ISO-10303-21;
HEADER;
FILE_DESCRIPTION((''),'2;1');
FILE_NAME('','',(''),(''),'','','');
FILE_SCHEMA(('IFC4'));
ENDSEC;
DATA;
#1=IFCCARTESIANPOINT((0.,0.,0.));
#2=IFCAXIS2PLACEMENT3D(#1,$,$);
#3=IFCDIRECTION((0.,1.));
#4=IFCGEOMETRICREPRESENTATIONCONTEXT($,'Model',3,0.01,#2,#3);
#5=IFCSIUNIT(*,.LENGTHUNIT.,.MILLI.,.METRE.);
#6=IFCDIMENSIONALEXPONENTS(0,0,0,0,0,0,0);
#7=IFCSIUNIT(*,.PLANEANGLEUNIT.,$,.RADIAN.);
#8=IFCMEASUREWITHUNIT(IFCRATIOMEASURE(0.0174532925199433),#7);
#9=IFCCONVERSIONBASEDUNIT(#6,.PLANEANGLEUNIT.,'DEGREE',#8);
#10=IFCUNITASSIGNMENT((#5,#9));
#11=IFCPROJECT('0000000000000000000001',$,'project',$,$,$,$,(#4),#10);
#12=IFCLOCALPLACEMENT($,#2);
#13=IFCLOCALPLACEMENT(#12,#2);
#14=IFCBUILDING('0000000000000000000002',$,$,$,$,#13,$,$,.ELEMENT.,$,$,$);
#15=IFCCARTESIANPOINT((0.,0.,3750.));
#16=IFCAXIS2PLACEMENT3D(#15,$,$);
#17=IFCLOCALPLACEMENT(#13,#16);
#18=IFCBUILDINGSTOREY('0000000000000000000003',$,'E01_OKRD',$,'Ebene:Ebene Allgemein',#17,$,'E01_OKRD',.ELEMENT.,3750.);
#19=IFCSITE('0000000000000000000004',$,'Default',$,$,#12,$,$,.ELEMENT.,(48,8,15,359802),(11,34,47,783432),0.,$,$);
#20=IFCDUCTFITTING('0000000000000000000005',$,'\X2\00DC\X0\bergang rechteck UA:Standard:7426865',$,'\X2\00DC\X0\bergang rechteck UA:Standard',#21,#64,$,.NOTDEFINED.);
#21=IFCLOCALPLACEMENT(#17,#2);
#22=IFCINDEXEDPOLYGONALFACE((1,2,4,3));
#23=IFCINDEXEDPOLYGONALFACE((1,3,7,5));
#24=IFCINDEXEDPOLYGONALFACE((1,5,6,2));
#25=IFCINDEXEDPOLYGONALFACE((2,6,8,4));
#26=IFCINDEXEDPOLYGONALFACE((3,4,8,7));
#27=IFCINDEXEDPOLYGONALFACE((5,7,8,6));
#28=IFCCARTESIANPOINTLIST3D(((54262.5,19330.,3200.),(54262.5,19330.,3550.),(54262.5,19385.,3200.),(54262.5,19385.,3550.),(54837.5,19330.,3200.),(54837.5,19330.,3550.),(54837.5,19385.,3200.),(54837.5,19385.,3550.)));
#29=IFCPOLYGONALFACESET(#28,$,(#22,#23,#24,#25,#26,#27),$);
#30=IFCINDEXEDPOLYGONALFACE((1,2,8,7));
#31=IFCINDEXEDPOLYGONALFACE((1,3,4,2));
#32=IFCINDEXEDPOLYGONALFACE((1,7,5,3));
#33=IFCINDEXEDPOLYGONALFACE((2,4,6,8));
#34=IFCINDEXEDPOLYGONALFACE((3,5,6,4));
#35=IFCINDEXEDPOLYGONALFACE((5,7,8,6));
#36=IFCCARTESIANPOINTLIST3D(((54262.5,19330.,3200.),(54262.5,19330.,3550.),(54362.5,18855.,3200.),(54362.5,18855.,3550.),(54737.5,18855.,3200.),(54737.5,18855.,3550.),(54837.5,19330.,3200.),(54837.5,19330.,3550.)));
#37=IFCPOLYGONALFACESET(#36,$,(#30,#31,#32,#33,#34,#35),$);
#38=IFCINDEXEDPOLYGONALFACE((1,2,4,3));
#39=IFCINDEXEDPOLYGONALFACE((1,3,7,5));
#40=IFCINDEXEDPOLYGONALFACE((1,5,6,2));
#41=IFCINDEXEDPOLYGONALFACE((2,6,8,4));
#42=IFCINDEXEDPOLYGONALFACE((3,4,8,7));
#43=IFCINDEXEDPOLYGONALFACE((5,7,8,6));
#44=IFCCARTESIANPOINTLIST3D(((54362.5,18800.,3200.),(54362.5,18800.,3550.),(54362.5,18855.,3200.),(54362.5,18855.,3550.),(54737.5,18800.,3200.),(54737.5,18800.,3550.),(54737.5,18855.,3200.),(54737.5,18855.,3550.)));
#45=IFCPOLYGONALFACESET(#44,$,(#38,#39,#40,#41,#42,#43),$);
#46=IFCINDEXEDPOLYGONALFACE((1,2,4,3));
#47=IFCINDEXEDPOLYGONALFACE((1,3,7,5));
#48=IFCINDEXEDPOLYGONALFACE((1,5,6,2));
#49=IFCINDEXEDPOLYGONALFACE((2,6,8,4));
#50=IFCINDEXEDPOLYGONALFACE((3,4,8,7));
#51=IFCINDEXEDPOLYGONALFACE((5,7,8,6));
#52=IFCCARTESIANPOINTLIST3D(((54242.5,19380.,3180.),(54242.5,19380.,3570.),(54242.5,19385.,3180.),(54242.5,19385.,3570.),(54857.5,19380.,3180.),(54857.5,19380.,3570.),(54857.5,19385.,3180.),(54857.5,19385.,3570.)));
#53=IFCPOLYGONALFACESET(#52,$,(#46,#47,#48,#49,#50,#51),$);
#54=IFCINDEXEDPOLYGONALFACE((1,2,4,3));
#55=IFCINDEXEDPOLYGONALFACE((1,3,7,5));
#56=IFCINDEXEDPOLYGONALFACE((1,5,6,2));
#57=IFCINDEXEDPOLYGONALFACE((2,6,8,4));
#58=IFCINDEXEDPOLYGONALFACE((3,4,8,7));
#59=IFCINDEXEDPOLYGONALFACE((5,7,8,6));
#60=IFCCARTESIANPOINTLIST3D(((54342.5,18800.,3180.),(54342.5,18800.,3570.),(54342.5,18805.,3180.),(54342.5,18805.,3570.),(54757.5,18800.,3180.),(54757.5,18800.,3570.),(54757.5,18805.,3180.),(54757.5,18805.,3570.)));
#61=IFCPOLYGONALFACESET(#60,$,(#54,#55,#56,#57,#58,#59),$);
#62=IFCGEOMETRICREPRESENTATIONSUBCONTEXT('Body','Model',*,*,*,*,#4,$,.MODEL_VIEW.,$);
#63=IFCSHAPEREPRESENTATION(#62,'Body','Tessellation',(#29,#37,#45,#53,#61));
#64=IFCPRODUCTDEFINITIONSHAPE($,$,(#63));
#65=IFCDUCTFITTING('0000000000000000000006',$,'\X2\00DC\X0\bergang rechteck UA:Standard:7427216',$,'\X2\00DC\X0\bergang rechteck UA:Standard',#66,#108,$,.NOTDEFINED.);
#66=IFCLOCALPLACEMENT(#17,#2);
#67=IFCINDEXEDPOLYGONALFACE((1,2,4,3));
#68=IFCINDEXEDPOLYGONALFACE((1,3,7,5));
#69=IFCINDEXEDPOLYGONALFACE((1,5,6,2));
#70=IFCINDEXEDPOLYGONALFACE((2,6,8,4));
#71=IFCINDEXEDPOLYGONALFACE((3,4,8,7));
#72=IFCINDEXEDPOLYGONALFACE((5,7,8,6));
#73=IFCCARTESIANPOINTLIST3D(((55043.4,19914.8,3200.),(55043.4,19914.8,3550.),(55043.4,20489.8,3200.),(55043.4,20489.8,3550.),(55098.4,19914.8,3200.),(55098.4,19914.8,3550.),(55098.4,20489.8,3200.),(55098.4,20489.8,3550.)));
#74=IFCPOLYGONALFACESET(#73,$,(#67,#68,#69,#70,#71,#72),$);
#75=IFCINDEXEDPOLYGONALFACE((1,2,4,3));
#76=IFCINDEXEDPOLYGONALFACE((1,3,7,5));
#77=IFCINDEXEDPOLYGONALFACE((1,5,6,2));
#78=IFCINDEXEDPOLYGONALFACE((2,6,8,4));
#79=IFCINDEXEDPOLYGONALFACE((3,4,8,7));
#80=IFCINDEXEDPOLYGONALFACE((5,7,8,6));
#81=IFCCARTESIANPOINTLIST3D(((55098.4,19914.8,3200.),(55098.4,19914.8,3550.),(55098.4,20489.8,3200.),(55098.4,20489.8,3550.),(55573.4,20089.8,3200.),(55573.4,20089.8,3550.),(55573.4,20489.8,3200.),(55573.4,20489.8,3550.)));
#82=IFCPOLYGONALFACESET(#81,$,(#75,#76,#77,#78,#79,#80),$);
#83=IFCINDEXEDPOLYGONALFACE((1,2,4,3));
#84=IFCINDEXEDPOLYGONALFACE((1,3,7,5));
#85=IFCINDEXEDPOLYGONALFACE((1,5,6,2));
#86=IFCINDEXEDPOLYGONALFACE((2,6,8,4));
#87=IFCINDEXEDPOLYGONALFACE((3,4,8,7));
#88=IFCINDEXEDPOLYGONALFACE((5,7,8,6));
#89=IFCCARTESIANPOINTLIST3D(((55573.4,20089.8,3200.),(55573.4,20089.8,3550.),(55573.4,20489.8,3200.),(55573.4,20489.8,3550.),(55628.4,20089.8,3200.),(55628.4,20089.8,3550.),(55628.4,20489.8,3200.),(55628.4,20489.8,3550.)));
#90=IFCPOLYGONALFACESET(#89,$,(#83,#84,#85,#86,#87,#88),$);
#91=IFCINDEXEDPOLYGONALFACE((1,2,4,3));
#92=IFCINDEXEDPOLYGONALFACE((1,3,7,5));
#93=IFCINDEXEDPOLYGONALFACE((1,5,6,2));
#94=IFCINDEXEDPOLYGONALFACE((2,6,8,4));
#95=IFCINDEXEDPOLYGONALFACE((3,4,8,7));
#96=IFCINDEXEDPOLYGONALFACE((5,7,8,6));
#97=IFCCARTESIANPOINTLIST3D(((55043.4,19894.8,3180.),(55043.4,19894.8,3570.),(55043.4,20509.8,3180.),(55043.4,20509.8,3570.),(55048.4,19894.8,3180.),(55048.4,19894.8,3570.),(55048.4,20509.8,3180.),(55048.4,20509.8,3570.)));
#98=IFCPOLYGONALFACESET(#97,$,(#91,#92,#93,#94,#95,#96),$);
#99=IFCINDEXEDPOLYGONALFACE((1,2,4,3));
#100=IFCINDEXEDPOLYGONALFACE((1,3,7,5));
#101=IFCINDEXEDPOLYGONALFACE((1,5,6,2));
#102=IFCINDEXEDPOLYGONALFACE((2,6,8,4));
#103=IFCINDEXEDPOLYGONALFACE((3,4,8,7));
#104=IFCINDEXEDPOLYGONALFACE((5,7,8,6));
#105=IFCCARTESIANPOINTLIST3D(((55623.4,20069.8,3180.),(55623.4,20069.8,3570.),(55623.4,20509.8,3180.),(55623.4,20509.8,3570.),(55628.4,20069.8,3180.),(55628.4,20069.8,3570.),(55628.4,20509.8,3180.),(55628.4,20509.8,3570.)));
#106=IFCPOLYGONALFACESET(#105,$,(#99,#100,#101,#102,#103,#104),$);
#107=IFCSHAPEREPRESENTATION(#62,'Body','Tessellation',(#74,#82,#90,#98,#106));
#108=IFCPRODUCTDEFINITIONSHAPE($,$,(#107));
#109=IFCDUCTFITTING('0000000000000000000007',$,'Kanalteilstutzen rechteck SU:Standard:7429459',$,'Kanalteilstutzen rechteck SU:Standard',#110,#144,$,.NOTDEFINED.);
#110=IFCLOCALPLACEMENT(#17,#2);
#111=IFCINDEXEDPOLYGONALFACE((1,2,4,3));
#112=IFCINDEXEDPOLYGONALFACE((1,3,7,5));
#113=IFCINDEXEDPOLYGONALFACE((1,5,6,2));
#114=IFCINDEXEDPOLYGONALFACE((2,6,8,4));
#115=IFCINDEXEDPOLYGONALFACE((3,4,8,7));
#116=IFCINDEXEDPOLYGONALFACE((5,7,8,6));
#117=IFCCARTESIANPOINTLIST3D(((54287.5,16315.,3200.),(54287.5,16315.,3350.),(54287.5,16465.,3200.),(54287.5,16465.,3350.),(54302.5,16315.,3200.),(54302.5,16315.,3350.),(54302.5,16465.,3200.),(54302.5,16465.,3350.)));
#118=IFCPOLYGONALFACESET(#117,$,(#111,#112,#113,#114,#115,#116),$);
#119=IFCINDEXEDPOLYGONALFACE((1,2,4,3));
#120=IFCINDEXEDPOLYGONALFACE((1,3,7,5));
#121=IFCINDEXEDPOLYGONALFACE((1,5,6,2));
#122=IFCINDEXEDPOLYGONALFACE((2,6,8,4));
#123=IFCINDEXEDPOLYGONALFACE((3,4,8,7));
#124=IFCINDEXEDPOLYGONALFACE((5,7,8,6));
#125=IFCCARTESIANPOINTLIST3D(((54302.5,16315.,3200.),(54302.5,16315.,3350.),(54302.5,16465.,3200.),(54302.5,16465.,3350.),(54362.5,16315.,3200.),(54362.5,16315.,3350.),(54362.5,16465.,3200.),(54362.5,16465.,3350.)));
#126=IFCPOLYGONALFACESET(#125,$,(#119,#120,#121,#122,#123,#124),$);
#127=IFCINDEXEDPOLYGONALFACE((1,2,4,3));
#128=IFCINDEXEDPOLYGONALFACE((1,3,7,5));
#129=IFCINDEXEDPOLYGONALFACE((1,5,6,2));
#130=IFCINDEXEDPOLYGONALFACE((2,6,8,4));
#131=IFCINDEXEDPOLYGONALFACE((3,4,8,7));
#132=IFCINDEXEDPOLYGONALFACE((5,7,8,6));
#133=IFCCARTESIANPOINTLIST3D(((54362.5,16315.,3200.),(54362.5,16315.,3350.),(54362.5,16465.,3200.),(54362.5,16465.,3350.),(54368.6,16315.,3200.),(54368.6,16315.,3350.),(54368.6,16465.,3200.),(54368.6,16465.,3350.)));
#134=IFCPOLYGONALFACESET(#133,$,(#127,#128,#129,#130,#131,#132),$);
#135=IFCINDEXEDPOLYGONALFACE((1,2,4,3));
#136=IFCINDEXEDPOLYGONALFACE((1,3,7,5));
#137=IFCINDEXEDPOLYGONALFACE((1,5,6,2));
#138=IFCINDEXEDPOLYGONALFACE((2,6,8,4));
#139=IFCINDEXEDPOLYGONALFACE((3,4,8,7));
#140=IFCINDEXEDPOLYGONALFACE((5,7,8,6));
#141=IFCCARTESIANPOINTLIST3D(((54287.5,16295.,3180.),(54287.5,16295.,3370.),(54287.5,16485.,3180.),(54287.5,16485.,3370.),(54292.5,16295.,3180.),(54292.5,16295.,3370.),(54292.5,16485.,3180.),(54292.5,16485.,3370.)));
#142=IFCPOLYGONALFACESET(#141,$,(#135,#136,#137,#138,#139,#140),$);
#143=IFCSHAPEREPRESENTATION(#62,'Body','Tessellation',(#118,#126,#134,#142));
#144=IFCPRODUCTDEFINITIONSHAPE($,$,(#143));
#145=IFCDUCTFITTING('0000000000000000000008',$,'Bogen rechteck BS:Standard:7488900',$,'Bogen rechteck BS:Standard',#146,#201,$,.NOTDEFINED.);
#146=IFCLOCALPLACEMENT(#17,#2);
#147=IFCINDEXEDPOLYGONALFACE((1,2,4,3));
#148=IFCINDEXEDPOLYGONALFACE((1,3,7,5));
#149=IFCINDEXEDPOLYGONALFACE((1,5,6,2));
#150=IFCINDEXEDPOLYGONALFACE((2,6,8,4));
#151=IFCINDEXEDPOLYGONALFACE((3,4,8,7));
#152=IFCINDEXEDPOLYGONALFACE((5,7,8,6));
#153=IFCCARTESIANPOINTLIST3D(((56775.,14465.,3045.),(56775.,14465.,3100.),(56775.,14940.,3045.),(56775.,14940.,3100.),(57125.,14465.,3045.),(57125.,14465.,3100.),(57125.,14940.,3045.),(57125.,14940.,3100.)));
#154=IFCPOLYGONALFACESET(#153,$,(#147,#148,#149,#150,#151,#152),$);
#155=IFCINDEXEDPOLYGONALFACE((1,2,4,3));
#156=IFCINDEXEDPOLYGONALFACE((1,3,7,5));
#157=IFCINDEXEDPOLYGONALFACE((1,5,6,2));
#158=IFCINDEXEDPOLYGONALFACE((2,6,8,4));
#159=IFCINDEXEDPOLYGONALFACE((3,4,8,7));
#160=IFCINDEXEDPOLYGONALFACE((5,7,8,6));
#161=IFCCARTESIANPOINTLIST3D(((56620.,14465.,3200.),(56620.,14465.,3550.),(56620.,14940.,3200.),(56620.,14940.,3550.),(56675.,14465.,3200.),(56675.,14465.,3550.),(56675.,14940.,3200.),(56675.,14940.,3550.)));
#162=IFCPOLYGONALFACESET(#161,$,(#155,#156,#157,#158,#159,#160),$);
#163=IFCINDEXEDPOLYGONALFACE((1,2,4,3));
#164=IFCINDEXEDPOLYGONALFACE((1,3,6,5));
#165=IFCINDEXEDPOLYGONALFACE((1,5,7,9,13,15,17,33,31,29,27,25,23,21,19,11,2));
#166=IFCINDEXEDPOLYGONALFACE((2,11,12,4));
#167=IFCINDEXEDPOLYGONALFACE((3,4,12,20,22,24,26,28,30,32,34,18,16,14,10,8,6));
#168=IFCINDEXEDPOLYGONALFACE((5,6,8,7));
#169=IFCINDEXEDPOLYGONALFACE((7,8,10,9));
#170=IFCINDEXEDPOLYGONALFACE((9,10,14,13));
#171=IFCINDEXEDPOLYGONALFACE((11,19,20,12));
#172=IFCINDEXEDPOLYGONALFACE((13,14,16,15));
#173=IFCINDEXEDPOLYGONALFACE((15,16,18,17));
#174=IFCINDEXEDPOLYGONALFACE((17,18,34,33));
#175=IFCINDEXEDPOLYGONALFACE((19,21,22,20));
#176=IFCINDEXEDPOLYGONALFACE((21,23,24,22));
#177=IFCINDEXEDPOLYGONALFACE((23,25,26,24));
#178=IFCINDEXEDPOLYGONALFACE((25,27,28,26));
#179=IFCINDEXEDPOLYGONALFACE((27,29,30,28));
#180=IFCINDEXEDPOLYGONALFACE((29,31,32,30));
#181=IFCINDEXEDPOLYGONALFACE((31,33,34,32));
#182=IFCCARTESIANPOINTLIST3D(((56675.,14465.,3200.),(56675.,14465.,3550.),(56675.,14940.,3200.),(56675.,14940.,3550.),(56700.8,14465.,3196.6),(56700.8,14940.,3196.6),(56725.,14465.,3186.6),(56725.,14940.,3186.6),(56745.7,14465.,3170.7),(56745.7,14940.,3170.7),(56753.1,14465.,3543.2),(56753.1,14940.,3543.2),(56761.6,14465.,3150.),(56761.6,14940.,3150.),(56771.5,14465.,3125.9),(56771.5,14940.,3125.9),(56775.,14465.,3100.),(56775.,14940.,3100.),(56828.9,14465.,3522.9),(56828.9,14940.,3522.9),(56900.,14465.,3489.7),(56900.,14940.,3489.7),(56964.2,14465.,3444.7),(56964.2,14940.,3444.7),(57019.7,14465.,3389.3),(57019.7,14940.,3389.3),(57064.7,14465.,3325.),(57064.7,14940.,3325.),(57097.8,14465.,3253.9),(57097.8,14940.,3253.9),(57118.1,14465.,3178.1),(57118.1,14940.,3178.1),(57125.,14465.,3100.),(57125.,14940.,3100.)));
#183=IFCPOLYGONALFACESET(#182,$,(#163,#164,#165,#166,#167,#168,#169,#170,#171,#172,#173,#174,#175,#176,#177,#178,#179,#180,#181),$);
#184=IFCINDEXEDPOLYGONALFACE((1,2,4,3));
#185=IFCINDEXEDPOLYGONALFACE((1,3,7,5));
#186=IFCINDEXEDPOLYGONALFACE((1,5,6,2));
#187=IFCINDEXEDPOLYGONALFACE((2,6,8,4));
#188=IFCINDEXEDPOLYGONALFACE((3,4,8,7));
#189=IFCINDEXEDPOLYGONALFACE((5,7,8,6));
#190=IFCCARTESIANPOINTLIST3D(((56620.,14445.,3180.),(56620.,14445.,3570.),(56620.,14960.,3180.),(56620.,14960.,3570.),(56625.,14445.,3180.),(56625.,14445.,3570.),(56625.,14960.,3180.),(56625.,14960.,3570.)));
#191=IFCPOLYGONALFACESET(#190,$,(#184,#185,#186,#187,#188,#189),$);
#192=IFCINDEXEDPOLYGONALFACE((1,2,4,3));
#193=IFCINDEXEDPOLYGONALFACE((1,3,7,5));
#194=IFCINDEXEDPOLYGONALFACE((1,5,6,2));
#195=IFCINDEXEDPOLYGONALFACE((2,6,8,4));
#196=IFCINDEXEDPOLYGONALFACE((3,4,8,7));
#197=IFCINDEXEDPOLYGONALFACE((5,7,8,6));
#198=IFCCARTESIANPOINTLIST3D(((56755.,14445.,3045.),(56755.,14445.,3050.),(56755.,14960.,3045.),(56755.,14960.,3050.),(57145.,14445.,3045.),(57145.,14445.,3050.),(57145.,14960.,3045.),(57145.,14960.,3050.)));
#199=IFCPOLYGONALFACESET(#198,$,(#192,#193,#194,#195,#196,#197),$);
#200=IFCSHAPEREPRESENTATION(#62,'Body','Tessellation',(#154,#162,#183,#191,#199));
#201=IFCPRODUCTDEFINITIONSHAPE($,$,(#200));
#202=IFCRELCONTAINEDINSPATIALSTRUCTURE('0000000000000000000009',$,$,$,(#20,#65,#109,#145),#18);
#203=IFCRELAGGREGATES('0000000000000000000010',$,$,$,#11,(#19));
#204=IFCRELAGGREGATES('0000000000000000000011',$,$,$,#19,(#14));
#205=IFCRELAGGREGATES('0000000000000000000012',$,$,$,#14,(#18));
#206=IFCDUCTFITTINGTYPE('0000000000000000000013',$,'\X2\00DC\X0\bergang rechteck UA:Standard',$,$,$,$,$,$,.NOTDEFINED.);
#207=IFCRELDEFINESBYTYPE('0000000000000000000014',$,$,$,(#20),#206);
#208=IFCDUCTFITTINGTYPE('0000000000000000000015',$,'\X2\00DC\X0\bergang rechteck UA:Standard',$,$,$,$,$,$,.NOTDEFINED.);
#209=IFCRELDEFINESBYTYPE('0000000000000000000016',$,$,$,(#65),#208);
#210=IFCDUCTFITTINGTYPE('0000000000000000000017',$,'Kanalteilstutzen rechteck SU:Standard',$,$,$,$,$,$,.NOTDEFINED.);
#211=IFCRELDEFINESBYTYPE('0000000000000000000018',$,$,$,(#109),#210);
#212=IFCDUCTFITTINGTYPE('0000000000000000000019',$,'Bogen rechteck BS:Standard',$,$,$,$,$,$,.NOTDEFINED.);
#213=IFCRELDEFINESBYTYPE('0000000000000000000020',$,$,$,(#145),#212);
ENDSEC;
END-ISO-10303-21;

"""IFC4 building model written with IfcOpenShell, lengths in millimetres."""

from ifc_helpers import new_model, entity, si_unit, converted_unit, direction, frame, frame_2d, origin, origin_2d_with_axis, place, context, subcontext, project, spatial, polyline, circle_curve, parameter, trimmed, segment, composite_curve, rectangle, outline, extrude, source, transform, mapped, type_object, type_shapes, element, save


model = new_model("IFC4")

# Units and contexts
model_context = context("Model", 3, precision=0.01, world=origin(), true_north=direction((0.0, 1.0)))
body_context = subcontext(model_context, "Body", "Model", "MODEL_VIEW")
ifc_project = project(units=[si_unit("LENGTHUNIT", "METRE", prefix="MILLI"), converted_unit("PLANEANGLEUNIT", "DEGREE", entity("IfcRatioMeasure", 0.0174532925199433), si_unit("PLANEANGLEUNIT", "RADIAN"), dimensions=[0, 0, 0, 0, 0, 0, 0])], contexts=[model_context])

# Site, building, storey
site_placement = place(None, origin())
site = spatial("IfcSite", under=ifc_project, at=site_placement, Name="Default", CompositionType="ELEMENT", RefLatitude=(48, 8, 15, 359802), RefLongitude=(11, 34, 47, 783432), RefElevation=0.0)
building_placement = place(site_placement, origin())
building = spatial("IfcBuilding", under=site, at=building_placement, CompositionType="ELEMENT")
storey_placement = place(building_placement, frame((0.0, 0.0, 3750.0)))
storey = spatial("IfcBuildingStorey", under=building, at=storey_placement, Name="E01_OKRD", ObjectType="Ebene:Ebene Allgemein", LongName="E01_OKRD", CompositionType="ELEMENT", Elevation=3750.0)

# Duct fittings
duct_fitting_type_1 = type_object("IfcDuctFittingType", Name="Übergang rechteck UA:Standard", PredefinedType="NOTDEFINED")
shared_shape_1 = source(origin(), body_context, "Body", "SweptSolid", [
    extrude(rectangle(XDim=55.0, YDim=575.0, at=frame_2d((0.0, 0.0), x_axis=(1.0, 0.0))), frame((557.5, 0.0, -175.0)), (0.0, 0.0, 1.0), 350.0),
    extrude(outline(polyline([(-193.8, -232.4), (291.6, -232.4), (173.2, 330.3), (-271.0, 134.6), (-193.8, -232.4)])), frame((292.5, 0.0, -175.0), z_axis=(0.0, 0.0, 1.0), x_axis=(0.97855, -0.20601, 0.0)), (0.0, 0.0, 1.0), 350.0),
    extrude(rectangle(XDim=55.0, YDim=375.0, at=frame_2d((0.0, 0.0), x_axis=(1.0, 0.0))), frame((27.5, 0.0, -175.0)), (0.0, 0.0, 1.0), 350.0),
    extrude(rectangle(XDim=5.0, YDim=615.0, at=origin_2d_with_axis()), frame((582.5, 0.0, -195.0)), (0.0, 0.0, 1.0), 390.0),
    extrude(rectangle(XDim=5.0, YDim=415.0, at=frame_2d((0.0, 0.0), x_axis=(1.0, 0.0))), frame((2.5, 0.0, -195.0)), (0.0, 0.0, 1.0), 390.0),
])
type_shapes(duct_fitting_type_1, [shared_shape_1])
duct_fitting_1_placement = place(storey_placement, frame((54550.0, 18800.0, 3375.0), z_axis=(0.0, 0.0, 1.0), x_axis=(0.0, 1.0, 0.0)))
element("IfcDuctFitting", 1, at=duct_fitting_1_placement, inside=storey, type_object=duct_fitting_type_1, Name="Übergang rechteck UA:Standard:7426865", ObjectType="Übergang rechteck UA:Standard", PredefinedType="NOTDEFINED", context=body_context, shape_type="MappedRepresentation", body=[
    mapped(shared_shape_1, transform((0.0, 0.0, 0.0), scale=1.0)),
])
duct_fitting_type_2 = type_object("IfcDuctFittingType", Name="Übergang rechteck UA:Standard", PredefinedType="NOTDEFINED")
shared_shape_2 = source(origin(), body_context, "Body", "SweptSolid", [
    extrude(rectangle(XDim=55.0, YDim=575.0, at=frame_2d((0.0, 0.0), x_axis=(1.0, 0.0))), frame((557.5, 87.5, -175.0)), (0.0, 0.0, 1.0), 350.0),
    extrude(outline(polyline([(-237.5, -243.8), (237.5, -243.8), (237.5, 331.2), (-237.5, 156.2), (-237.5, -243.8)])), frame((292.5, 43.8, -175.0)), (0.0, 0.0, 1.0), 350.0),
    extrude(rectangle(XDim=55.0, YDim=400.0, at=frame_2d((0.0, 0.0), x_axis=(1.0, 0.0))), frame((27.5, 0.0, -175.0)), (0.0, 0.0, 1.0), 350.0),
    extrude(rectangle(XDim=5.0, YDim=615.0, at=origin_2d_with_axis()), frame((582.5, 87.5, -195.0)), (0.0, 0.0, 1.0), 390.0),
    extrude(rectangle(XDim=5.0, YDim=440.0, at=frame_2d((0.0, 0.0), x_axis=(1.0, 0.0))), frame((2.5, 0.0, -195.0)), (0.0, 0.0, 1.0), 390.0),
])
type_shapes(duct_fitting_type_2, [shared_shape_2])
duct_fitting_2_placement = place(storey_placement, frame((55628.4, 20289.8, 3375.0), z_axis=(0.0, 0.0, 1.0), x_axis=(-1.0, 0.0, 0.0)))
element("IfcDuctFitting", 2, at=duct_fitting_2_placement, inside=storey, type_object=duct_fitting_type_2, Name="Übergang rechteck UA:Standard:7427216", ObjectType="Übergang rechteck UA:Standard", PredefinedType="NOTDEFINED", context=body_context, shape_type="MappedRepresentation", body=[
    mapped(shared_shape_2, transform((0.0, 0.0, 0.0), scale=1.0)),
])
duct_fitting_type_3 = type_object("IfcDuctFittingType", Name="Kanalteilstutzen rechteck SU:Standard", PredefinedType="NOTDEFINED")
shared_shape_3 = source(origin(), body_context, "Body", "SweptSolid", [
    extrude(rectangle(XDim=15.0, YDim=150.0, at=origin_2d_with_axis()), frame((67.5, 0.0, -75.0)), (0.0, 0.0, 1.0), 150.0),
    extrude(rectangle(XDim=60.0, YDim=150.0, at=frame_2d((0.0, 0.0), x_axis=(1.0, 0.0))), frame((30.0, 0.0, -75.0)), (0.0, 0.0, 1.0), 150.0),
    extrude(rectangle(XDim=6.1, YDim=150.0, at=frame_2d((0.0, 0.0), x_axis=(1.0, 0.0))), frame((-3.0, 0.0, -75.0)), (0.0, 0.0, 1.0), 150.0),
    extrude(rectangle(XDim=5.0, YDim=190.0, at=origin_2d_with_axis()), frame((72.5, 0.0, -95.0)), (0.0, 0.0, 1.0), 190.0),
])
type_shapes(duct_fitting_type_3, [shared_shape_3])
duct_fitting_3_placement = place(storey_placement, frame((54362.5, 16390.0, 3275.0), z_axis=(0.000013, 0.0, -1.0), x_axis=(-1.0, 0.0, -0.000013)))
element("IfcDuctFitting", 3, at=duct_fitting_3_placement, inside=storey, type_object=duct_fitting_type_3, Name="Kanalteilstutzen rechteck SU:Standard:7429459", ObjectType="Kanalteilstutzen rechteck SU:Standard", PredefinedType="NOTDEFINED", context=body_context, shape_type="MappedRepresentation", body=[
    mapped(shared_shape_3, transform((0.0, 0.0, 0.0), scale=1.0)),
])
duct_fitting_type_4 = type_object("IfcDuctFittingType", Name="Bogen rechteck BS:Standard", PredefinedType="NOTDEFINED")
shared_shape_4 = source(origin(), body_context, "Body", "SweptSolid", [
    extrude(rectangle(XDim=55.0, YDim=350.0, at=origin_2d_with_axis()), frame((0.0, 302.5, -237.5), z_axis=(0.0, 0.0, 1.0), x_axis=(0.0, 1.0, 0.0)), (0.0, 0.0, 1.0), 475.0),
    extrude(rectangle(XDim=350.0, YDim=55.0, at=frame_2d((0.0, 0.0), x_axis=(1.0, 0.0))), frame((-302.5, 0.0, -237.5), z_axis=(0.0, 0.0, 1.0), x_axis=(0.0, -1.0, 0.0)), (0.0, 0.0, 1.0), 475.0),
    extrude(outline(composite_curve([segment(polyline([(-312.5, -137.5), (37.5, -137.5)]), True, "CONTINUOUS"), segment(trimmed(circle_curve(frame_2d((137.5, -137.5), x_axis=(0.0, 1.0)), 100.0), [parameter(0.0)], [parameter(90.0)], True, "PARAMETER"), False, "CONTINUOUS"), segment(polyline([(137.5, -37.5), (137.5, 312.5)]), True, "CONTINUOUS"), segment(trimmed(circle_curve(frame_2d((137.5, -137.5), x_axis=(0.0, 1.0)), 450.0), [parameter(0.0)], [parameter(90.0)], True, "PARAMETER"), True, "CONTINUOUS")], self_intersect=False)), frame((-137.5, 137.5, -237.5), z_axis=(0.0, 0.0, 1.0), x_axis=(-1.0, 0.0, 0.0)), (0.0, 0.0, 1.0), 475.0),
    extrude(rectangle(XDim=5.0, YDim=390.0, at=frame_2d((0.0, 0.0), x_axis=(1.0, 0.0))), frame((-327.5, 0.0, -257.5)), (0.0, 0.0, 1.0), 515.0),
    extrude(rectangle(XDim=5.0, YDim=390.0, at=frame_2d((0.0, 0.0), x_axis=(1.0, 0.0))), frame((0.0, 327.5, -257.5), z_axis=(0.0, 0.0, 1.0), x_axis=(0.0, 1.0, 0.0)), (0.0, 0.0, 1.0), 515.0),
])
type_shapes(duct_fitting_type_4, [shared_shape_4])
duct_fitting_4_placement = place(storey_placement, frame((56950.0, 14702.5, 3375.0), z_axis=(0.0, 1.0, 0.0), x_axis=(1.0, 0.0, 0.0)))
element("IfcDuctFitting", 4, at=duct_fitting_4_placement, inside=storey, type_object=duct_fitting_type_4, Name="Bogen rechteck BS:Standard:7488900", ObjectType="Bogen rechteck BS:Standard", PredefinedType="NOTDEFINED", context=body_context, shape_type="MappedRepresentation", body=[
    mapped(shared_shape_4, transform((0.0, 0.0, 0.0), scale=1.0)),
])

save(model, "model.ifc")
